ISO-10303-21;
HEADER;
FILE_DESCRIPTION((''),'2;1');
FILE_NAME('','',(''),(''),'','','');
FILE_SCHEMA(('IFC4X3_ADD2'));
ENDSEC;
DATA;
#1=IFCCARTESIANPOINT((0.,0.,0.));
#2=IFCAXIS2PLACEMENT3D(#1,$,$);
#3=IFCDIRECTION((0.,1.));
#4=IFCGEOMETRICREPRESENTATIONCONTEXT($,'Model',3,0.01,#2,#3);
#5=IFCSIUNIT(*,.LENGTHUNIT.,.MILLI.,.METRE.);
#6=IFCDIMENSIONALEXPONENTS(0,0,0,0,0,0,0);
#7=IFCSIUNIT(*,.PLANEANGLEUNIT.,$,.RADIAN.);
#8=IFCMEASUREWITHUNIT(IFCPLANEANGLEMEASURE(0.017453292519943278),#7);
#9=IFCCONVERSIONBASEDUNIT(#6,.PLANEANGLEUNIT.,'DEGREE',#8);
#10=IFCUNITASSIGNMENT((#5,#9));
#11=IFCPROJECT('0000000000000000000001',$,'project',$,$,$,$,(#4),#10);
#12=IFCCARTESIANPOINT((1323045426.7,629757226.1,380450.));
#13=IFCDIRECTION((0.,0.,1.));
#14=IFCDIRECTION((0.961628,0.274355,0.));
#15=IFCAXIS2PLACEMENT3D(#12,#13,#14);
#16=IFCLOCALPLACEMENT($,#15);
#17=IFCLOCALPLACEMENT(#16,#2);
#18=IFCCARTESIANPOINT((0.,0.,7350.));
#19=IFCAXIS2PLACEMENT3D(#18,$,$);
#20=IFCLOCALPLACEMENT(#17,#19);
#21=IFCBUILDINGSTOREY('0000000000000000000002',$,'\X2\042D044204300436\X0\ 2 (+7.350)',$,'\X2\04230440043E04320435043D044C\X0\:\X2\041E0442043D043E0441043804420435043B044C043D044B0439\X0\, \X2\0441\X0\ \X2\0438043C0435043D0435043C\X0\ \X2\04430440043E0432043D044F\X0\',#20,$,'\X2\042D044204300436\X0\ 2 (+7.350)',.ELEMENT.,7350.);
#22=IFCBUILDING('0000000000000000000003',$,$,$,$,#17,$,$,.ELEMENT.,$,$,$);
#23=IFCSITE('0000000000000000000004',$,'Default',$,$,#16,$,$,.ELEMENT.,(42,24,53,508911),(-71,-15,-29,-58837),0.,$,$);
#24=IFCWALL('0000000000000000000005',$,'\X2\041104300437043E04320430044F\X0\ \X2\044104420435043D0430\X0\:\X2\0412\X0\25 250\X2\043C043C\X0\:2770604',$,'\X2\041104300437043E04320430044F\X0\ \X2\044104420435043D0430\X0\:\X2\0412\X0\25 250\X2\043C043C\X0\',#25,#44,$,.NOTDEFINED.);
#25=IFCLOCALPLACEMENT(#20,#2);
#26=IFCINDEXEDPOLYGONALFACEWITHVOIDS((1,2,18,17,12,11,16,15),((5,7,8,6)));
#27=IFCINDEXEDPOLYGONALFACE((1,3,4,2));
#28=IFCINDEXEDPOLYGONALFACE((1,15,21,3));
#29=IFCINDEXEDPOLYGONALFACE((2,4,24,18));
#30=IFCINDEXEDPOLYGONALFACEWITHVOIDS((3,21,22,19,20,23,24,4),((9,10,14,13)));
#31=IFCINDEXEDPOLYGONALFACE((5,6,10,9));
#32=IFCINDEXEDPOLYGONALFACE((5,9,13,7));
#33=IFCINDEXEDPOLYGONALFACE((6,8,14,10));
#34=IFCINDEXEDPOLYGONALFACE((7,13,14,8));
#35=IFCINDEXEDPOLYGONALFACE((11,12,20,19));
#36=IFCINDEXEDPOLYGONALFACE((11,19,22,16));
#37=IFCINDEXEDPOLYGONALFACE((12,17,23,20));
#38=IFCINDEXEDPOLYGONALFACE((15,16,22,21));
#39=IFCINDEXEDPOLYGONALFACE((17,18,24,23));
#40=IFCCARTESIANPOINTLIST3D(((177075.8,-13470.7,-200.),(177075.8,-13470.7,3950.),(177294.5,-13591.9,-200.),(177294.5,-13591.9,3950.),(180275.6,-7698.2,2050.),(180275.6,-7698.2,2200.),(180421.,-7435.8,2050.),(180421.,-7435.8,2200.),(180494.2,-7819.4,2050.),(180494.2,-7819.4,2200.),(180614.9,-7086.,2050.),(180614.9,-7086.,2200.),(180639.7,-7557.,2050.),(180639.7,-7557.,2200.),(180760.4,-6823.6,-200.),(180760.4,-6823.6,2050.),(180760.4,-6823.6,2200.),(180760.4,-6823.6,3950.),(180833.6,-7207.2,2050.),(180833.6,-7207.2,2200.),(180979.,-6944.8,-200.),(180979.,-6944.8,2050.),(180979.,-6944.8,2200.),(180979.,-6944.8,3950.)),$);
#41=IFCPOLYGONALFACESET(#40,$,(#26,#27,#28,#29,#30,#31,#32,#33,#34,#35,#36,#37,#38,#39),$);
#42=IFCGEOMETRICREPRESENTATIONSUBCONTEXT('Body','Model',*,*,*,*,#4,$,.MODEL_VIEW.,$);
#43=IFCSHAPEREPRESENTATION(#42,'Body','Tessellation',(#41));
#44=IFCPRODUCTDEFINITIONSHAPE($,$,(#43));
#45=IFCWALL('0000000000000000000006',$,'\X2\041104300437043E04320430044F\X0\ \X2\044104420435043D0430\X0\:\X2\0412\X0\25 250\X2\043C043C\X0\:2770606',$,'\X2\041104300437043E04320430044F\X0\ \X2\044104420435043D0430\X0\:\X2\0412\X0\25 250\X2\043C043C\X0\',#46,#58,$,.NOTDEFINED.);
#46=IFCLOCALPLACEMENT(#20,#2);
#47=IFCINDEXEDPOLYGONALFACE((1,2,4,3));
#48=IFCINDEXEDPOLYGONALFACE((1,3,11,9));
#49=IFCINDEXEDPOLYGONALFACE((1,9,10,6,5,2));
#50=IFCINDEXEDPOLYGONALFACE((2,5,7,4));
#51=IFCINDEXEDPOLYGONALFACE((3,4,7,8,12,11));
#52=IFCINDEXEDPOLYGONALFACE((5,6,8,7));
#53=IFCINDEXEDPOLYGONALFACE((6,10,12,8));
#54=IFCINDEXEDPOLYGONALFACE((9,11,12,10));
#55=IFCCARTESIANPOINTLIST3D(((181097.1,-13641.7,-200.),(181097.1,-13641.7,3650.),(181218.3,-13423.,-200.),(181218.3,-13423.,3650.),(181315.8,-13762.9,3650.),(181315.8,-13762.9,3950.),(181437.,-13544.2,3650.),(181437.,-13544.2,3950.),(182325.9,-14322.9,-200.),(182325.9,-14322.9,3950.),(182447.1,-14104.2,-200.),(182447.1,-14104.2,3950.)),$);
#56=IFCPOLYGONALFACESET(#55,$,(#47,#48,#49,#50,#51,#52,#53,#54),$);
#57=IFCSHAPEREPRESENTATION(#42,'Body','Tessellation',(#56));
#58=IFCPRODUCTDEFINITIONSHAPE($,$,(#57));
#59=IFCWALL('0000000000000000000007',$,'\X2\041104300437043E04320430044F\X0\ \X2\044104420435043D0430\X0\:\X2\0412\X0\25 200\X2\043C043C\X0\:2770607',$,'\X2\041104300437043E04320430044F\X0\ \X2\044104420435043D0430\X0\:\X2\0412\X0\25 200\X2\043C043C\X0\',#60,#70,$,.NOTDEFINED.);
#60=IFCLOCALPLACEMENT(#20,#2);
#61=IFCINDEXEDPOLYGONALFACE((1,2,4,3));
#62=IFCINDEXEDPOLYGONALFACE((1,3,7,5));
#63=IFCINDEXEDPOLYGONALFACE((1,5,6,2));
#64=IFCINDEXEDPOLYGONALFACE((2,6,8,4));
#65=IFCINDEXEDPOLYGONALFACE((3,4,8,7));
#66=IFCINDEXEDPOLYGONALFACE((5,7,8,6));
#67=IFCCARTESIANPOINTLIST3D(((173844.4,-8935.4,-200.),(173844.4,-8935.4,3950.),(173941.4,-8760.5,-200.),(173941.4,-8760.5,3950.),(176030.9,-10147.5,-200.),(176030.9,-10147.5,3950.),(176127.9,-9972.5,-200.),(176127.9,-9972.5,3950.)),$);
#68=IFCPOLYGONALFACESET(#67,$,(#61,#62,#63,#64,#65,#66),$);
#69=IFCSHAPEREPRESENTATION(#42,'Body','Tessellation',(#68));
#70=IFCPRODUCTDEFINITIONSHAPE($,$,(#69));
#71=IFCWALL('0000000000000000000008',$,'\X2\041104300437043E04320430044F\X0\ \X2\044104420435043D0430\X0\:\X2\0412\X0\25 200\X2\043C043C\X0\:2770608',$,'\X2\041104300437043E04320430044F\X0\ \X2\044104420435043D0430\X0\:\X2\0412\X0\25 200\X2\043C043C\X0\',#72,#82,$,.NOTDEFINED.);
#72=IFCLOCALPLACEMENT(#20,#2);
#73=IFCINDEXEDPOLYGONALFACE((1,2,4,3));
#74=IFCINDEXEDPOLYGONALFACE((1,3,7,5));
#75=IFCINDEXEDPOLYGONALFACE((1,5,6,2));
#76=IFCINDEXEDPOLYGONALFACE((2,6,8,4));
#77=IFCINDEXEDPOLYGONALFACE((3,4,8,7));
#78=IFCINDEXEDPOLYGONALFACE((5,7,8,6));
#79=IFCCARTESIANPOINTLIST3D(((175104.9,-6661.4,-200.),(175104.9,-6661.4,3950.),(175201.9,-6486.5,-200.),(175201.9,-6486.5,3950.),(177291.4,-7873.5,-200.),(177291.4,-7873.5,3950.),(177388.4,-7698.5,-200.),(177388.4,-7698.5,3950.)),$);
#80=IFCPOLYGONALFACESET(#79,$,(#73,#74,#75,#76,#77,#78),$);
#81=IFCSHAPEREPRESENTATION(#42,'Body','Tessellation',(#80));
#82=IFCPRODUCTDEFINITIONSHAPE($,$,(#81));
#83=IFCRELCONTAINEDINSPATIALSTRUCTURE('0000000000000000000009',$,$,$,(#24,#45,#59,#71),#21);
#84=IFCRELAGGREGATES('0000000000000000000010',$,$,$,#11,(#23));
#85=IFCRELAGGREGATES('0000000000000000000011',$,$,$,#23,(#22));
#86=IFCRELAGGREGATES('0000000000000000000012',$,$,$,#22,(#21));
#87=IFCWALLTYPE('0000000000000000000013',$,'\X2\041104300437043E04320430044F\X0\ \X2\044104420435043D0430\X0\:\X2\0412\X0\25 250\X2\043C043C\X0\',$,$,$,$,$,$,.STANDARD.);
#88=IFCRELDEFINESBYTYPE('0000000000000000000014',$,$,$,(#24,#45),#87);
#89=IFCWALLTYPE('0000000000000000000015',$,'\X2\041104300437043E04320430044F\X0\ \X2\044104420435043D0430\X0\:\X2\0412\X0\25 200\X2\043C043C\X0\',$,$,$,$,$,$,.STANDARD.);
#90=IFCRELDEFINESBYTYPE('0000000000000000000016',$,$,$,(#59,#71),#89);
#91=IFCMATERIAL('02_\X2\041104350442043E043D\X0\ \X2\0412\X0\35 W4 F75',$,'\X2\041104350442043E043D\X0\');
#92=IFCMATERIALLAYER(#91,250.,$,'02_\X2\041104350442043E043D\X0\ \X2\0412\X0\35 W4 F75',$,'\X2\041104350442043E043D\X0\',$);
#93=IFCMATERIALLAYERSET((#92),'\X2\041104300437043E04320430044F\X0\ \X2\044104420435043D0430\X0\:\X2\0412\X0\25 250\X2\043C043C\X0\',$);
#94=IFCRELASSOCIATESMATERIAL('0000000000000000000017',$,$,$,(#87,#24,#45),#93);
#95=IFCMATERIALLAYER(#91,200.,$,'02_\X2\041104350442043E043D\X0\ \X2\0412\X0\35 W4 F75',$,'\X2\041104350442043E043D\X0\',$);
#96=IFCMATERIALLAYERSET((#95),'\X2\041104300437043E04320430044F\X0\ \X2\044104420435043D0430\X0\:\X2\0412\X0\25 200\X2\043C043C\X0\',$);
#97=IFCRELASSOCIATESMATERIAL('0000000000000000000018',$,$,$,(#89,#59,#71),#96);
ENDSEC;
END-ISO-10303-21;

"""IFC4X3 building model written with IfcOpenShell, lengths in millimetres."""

from ifc_helpers import new_model, entity, si_unit, converted_unit, direction, frame, frame_2d, origin, place, context, subcontext, project, spatial, polyline, rectangle, extrude, clip, bounded_halfspace, material, layer, layer_set, type_object, element, save


model = new_model("IFC4X3")

# Units and contexts
model_context = context("Model", 3, precision=0.01, world=origin(), true_north=direction((0.0, 1.0)))
body_context = subcontext(model_context, "Body", "Model", "MODEL_VIEW")
ifc_project = project(units=[si_unit("LENGTHUNIT", "METRE", prefix="MILLI"), converted_unit("PLANEANGLEUNIT", "DEGREE", entity("IfcPlaneAngleMeasure", 0.017453292519943278), si_unit("PLANEANGLEUNIT", "RADIAN"), dimensions=[0, 0, 0, 0, 0, 0, 0])], contexts=[model_context])

# Site, building, storey
site_placement = place(None, frame((1323045426.7, 629757226.1, 380450.0), z_axis=(0.0, 0.0, 1.0), x_axis=(0.961628, 0.274355, 0.0)))
site = spatial("IfcSite", under=ifc_project, at=site_placement, Name="Default", CompositionType="ELEMENT", RefLatitude=(42, 24, 53, 508911), RefLongitude=(-71, -15, -29, -58837), RefElevation=0.0)
building_placement = place(site_placement, origin())
building = spatial("IfcBuilding", under=site, at=building_placement, CompositionType="ELEMENT")
storey_placement = place(building_placement, frame((0.0, 0.0, 7350.0)))
storey = spatial("IfcBuildingStorey", under=building, at=storey_placement, Name="Этаж 2 (+7.350)", ObjectType="Уровень:Относительный, с именем уровня", LongName="Этаж 2 (+7.350)", CompositionType="ELEMENT", Elevation=7350.0)

# Shared definitions
ifc_material = material(Name="02_Бетон В35 W4 F75", Category="Бетон")
ifc_layer_1 = layer(ifc_material, 250.0, Name="02_Бетон В35 W4 F75", Category="Бетон")
ifc_layer_set_1 = layer_set([ifc_layer_1], Name="Базовая стена:В25 250мм")
wall_type_1 = type_object("IfcWallType", Name="Базовая стена:В25 250мм", PredefinedType="STANDARD", material=ifc_layer_set_1)

# Wall, openings
wall_1_placement = place(storey_placement, frame((177185.1, -13531.3, -200.0), z_axis=(0.0, 0.0, 1.0), x_axis=(0.48481, 0.87462, 0.0)))
wall_1 = element("IfcWall", 1, at=wall_1_placement, inside=storey, type_object=wall_type_1, material=ifc_layer_set_1, Name="Базовая стена:В25 250мм:2770604", ObjectType="Базовая стена:В25 250мм", PredefinedType="NOTDEFINED", context=body_context, shape_type="Clipping", body=[
    clip(extrude(rectangle(XDim=7600.0, YDim=250.0, at=frame_2d((3800.0, 0.0), x_axis=(-1.0, 0.0))), origin(), (0.0, 0.0, 1.0), 4150.0), bounded_halfspace(frame((0.0, -125.0, 4150.0), z_axis=(0.0, 0.0, -1.0), x_axis=(-1.0, 0.0, 0.0)), True, frame((0.0, -125.0, 4150.0)), polyline([(0.0, 0.0), (7600.0, 0.0), (7600.0, 250.0), (5000.0, 250.0), (0.0, 250.0), (0.0, 0.0)]))),
])
opening_1_placement = place(wall_1_placement, frame((-74066.3, 161529.7, 2250.0), z_axis=(0.0, 0.0, 1.0), x_axis=(0.48481, -0.87462, 0.0)))
element("IfcOpeningElement", 2, at=opening_1_placement, cuts=wall_1, PredefinedType="OPENING", context=body_context, shape_type="SweptSolid", body=[
    extrude(rectangle(XDim=150.0, YDim=300.0, at=frame_2d((0.0, 0.0), x_axis=(1.0, 0.0))), frame((182020.6, -7693.6, 75.0), z_axis=(-0.87462, 0.48481, 0.0), x_axis=(0.0, 0.0, -1.0)), (0.0, 0.0, 1.0), 3048.0),
])
opening_2_placement = place(wall_1_placement, frame((-74066.3, 161529.7, 2250.0), z_axis=(0.0, 0.0, 1.0), x_axis=(0.48481, -0.87462, 0.0)))
element("IfcOpeningElement", 3, at=opening_2_placement, cuts=wall_1, PredefinedType="OPENING", context=body_context, shape_type="SweptSolid", body=[
    extrude(rectangle(XDim=150.0, YDim=300.0, at=frame_2d((0.0, 0.0), x_axis=(1.0, 0.0))), frame((181681.2, -8305.9, 75.0), z_axis=(-0.87462, 0.48481, 0.0), x_axis=(0.0, 0.0, -1.0)), (0.0, 0.0, 1.0), 3048.0),
])

# Wall, opening
wall_2_placement = place(storey_placement, frame((181157.7, -13532.4, -200.0), z_axis=(0.0, 0.0, 1.0), x_axis=(0.87462, -0.48481, 0.0)))
wall_2 = element("IfcWall", 4, at=wall_2_placement, inside=storey, type_object=wall_type_1, material=ifc_layer_set_1, Name="Базовая стена:В25 250мм:2770606", ObjectType="Базовая стена:В25 250мм", PredefinedType="NOTDEFINED", context=body_context, shape_type="Clipping", body=[
    clip(extrude(rectangle(XDim=1405.0, YDim=250.0, at=frame_2d((702.5, 0.0), x_axis=(-1.0, 0.0))), origin(), (0.0, 0.0, 1.0), 4150.0), bounded_halfspace(frame((250.0, -125.0, 4150.0), z_axis=(0.0, 0.0, -1.0), x_axis=(0.0, -1.0, 0.0)), True, frame((250.0, -125.0, 4150.0)), polyline([(0.0, 0.0), (1155.0, 0.0), (1155.0, 250.0), (0.0, 250.0), (0.0, 0.0)]))),
])
opening_3_placement = place(wall_2_placement, origin())
element("IfcOpeningElement", 5, at=opening_3_placement, cuts=wall_2, PredefinedType="OPENING", context=body_context, shape_type="SweptSolid", body=[
    extrude(rectangle(XDim=300.0, YDim=375.0, at=frame_2d((0.0, 0.0), x_axis=(0.0, 1.0))), frame((62.5, 125.0, 4000.0), z_axis=(0.0, -1.0, 0.0), x_axis=(-1.0, 0.0, 0.0)), (0.0, 0.0, 1.0), 250.0),
])

# Walls
ifc_layer_2 = layer(ifc_material, 200.0, Name="02_Бетон В35 W4 F75", Category="Бетон")
ifc_layer_set_2 = layer_set([ifc_layer_2], Name="Базовая стена:В25 200мм")
wall_type_2 = type_object("IfcWallType", Name="Базовая стена:В25 200мм", PredefinedType="STANDARD", material=ifc_layer_set_2)
wall_3_placement = place(storey_placement, frame((173892.9, -8848.0, -200.0), z_axis=(0.0, 0.0, 1.0), x_axis=(0.87462, -0.48481, 0.0)))
element("IfcWall", 6, at=wall_3_placement, inside=storey, type_object=wall_type_2, material=ifc_layer_set_2, Name="Базовая стена:В25 200мм:2770607", ObjectType="Базовая стена:В25 200мм", PredefinedType="NOTDEFINED", context=body_context, shape_type="Clipping", body=[
    clip(extrude(rectangle(XDim=2500.0, YDim=200.0, at=frame_2d((1250.0, 0.0), x_axis=(-1.0, 0.0))), origin(), (0.0, 0.0, 1.0), 4150.0), bounded_halfspace(frame((0.0, -100.0, 4150.0), z_axis=(0.0, 0.0, -1.0), x_axis=(0.0, -1.0, 0.0)), True, frame((0.0, -100.0, 4150.0)), polyline([(0.0, 0.0), (2500.0, 0.0), (2500.0, 200.0), (0.0, 200.0), (0.0, 0.0)]))),
])
wall_4_placement = place(storey_placement, frame((175153.4, -6574.0, -200.0), z_axis=(0.0, 0.0, 1.0), x_axis=(0.87462, -0.48481, 0.0)))
element("IfcWall", 7, at=wall_4_placement, inside=storey, type_object=wall_type_2, material=ifc_layer_set_2, Name="Базовая стена:В25 200мм:2770608", ObjectType="Базовая стена:В25 200мм", PredefinedType="NOTDEFINED", context=body_context, shape_type="Clipping", body=[
    clip(extrude(rectangle(XDim=2500.0, YDim=200.0, at=frame_2d((1250.0, 0.0), x_axis=(-1.0, 0.0))), origin(), (0.0, 0.0, 1.0), 4150.0), bounded_halfspace(frame((0.0, -100.0, 4150.0), z_axis=(0.0, 0.0, -1.0), x_axis=(0.0, -1.0, 0.0)), True, frame((0.0, -100.0, 4150.0)), polyline([(0.0, 0.0), (2500.0, 0.0), (2500.0, 200.0), (0.0, 200.0), (0.0, 0.0)]))),
])

save(model, "model.ifc")
